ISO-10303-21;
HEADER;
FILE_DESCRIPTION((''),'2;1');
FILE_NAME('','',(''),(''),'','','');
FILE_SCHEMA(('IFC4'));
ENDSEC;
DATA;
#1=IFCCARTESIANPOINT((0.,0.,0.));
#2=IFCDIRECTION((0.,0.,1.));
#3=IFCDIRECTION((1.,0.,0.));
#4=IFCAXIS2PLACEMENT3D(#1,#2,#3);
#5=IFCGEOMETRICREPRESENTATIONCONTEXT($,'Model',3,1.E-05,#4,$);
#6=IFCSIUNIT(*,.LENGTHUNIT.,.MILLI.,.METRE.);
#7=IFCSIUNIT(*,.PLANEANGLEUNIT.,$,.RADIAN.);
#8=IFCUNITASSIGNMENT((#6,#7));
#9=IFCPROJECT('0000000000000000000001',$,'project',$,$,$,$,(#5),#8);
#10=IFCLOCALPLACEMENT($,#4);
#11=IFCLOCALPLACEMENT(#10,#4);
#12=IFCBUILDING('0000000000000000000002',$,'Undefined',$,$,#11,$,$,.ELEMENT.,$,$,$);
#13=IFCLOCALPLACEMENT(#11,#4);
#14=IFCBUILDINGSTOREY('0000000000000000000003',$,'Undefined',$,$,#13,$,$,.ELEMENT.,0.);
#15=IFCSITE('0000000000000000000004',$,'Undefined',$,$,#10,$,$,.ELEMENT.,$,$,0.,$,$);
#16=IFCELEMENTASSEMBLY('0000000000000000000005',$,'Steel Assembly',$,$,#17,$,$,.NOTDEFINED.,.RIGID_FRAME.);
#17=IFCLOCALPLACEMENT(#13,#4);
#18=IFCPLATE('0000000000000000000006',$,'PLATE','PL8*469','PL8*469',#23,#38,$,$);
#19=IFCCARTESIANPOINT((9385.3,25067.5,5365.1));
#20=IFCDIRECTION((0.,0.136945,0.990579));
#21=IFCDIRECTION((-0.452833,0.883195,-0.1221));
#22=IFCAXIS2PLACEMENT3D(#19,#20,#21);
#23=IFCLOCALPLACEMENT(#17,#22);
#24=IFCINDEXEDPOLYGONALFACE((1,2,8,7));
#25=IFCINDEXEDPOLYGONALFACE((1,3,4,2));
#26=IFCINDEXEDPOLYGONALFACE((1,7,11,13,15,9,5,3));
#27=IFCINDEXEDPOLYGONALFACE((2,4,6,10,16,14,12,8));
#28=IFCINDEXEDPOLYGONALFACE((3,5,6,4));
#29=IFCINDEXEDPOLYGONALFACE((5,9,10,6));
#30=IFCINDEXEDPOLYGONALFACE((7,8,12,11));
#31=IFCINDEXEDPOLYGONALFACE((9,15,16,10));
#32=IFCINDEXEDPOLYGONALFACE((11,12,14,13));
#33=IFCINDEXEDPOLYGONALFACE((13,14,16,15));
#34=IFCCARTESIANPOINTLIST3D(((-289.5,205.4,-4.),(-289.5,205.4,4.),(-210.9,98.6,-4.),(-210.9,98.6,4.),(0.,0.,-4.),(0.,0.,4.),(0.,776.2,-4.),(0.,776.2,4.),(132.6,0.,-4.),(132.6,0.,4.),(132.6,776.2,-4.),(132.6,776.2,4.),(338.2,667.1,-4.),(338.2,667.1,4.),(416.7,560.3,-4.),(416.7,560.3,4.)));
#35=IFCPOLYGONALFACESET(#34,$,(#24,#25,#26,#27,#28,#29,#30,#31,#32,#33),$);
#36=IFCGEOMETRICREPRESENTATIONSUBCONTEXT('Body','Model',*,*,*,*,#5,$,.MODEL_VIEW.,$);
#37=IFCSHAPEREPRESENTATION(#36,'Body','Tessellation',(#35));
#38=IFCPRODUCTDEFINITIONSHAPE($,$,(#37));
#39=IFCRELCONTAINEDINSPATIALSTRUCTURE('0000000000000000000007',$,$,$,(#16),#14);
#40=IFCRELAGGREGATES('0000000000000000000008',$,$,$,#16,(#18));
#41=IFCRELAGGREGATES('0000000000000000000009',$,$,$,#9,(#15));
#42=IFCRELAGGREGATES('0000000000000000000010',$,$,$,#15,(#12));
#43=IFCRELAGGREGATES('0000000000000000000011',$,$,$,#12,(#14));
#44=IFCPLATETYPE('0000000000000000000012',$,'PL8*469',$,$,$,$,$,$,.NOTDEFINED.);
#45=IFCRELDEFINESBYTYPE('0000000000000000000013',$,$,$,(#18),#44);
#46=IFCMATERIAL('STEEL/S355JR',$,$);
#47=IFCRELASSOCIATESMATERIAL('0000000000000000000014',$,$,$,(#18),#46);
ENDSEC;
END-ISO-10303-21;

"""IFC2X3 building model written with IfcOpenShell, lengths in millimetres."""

from ifc_helpers import new_model, si_unit, frame, origin_with_axes, place, context, subcontext, project, spatial, polyline, outline, extrude, material, type_object, element, aggregate, save


model = new_model("IFC2X3")

# Units and contexts
model_context = context("Model", 3, precision=1e-05, world=origin_with_axes())
body_context = subcontext(model_context, "Body", "Model", "MODEL_VIEW")
ifc_project = project(units=[si_unit("LENGTHUNIT", "METRE", prefix="MILLI"), si_unit("PLANEANGLEUNIT", "RADIAN")], contexts=[model_context])

# Site, building, storey
site_placement = place(None, origin_with_axes())
site = spatial("IfcSite", under=ifc_project, at=site_placement, Name="Undefined", CompositionType="ELEMENT", RefElevation=0.0)
building_placement = place(site_placement, origin_with_axes())
building = spatial("IfcBuilding", under=site, at=building_placement, Name="Undefined", CompositionType="ELEMENT")
storey_placement = place(building_placement, origin_with_axes())
storey = spatial("IfcBuildingStorey", under=building, at=storey_placement, Name="Undefined", CompositionType="ELEMENT", Elevation=0.0)

# Shared definitions
ifc_material_1 = material(Name="STEEL/S355JR")

# Element assembly, plate
assembly_1_placement = place(storey_placement, origin_with_axes())
assembly_1 = element("IfcElementAssembly", 1, at=assembly_1_placement, inside=storey, Name="Steel Assembly", AssemblyPlace="NOTDEFINED", PredefinedType="RIGID_FRAME")
plate_type_1 = type_object("IfcPlateType", Name="PL8*469", PredefinedType="NOTDEFINED")
plate_1_placement = place(assembly_1_placement, frame((9385.3, 25067.5, 5365.1), z_axis=(0.0, 0.136945, 0.990579), x_axis=(-0.452833, 0.883195, -0.1221)))
plate_1 = element("IfcPlate", 2, at=plate_1_placement, type_object=plate_type_1, material=ifc_material_1, Name="PLATE", Description="PL8*469", ObjectType="PL8*469", context=body_context, shape_type="SweptSolid", body=[
    extrude(outline(polyline([(0.0, 0.0), (132.6, 0.0), (416.7, 560.3), (338.2, 667.1), (132.6, 776.2), (0.0, 776.2), (-289.5, 205.4), (-210.9, 98.6), (0.0, 0.0)])), frame((0.0, 0.0, -4.0), z_axis=(0.0, 0.0, 1.0), x_axis=(1.0, 0.0, 0.0)), (0.0, 0.0, 1.0), 8.0),
])

aggregate(assembly_1, [plate_1])

save(model, "model.ifc")
